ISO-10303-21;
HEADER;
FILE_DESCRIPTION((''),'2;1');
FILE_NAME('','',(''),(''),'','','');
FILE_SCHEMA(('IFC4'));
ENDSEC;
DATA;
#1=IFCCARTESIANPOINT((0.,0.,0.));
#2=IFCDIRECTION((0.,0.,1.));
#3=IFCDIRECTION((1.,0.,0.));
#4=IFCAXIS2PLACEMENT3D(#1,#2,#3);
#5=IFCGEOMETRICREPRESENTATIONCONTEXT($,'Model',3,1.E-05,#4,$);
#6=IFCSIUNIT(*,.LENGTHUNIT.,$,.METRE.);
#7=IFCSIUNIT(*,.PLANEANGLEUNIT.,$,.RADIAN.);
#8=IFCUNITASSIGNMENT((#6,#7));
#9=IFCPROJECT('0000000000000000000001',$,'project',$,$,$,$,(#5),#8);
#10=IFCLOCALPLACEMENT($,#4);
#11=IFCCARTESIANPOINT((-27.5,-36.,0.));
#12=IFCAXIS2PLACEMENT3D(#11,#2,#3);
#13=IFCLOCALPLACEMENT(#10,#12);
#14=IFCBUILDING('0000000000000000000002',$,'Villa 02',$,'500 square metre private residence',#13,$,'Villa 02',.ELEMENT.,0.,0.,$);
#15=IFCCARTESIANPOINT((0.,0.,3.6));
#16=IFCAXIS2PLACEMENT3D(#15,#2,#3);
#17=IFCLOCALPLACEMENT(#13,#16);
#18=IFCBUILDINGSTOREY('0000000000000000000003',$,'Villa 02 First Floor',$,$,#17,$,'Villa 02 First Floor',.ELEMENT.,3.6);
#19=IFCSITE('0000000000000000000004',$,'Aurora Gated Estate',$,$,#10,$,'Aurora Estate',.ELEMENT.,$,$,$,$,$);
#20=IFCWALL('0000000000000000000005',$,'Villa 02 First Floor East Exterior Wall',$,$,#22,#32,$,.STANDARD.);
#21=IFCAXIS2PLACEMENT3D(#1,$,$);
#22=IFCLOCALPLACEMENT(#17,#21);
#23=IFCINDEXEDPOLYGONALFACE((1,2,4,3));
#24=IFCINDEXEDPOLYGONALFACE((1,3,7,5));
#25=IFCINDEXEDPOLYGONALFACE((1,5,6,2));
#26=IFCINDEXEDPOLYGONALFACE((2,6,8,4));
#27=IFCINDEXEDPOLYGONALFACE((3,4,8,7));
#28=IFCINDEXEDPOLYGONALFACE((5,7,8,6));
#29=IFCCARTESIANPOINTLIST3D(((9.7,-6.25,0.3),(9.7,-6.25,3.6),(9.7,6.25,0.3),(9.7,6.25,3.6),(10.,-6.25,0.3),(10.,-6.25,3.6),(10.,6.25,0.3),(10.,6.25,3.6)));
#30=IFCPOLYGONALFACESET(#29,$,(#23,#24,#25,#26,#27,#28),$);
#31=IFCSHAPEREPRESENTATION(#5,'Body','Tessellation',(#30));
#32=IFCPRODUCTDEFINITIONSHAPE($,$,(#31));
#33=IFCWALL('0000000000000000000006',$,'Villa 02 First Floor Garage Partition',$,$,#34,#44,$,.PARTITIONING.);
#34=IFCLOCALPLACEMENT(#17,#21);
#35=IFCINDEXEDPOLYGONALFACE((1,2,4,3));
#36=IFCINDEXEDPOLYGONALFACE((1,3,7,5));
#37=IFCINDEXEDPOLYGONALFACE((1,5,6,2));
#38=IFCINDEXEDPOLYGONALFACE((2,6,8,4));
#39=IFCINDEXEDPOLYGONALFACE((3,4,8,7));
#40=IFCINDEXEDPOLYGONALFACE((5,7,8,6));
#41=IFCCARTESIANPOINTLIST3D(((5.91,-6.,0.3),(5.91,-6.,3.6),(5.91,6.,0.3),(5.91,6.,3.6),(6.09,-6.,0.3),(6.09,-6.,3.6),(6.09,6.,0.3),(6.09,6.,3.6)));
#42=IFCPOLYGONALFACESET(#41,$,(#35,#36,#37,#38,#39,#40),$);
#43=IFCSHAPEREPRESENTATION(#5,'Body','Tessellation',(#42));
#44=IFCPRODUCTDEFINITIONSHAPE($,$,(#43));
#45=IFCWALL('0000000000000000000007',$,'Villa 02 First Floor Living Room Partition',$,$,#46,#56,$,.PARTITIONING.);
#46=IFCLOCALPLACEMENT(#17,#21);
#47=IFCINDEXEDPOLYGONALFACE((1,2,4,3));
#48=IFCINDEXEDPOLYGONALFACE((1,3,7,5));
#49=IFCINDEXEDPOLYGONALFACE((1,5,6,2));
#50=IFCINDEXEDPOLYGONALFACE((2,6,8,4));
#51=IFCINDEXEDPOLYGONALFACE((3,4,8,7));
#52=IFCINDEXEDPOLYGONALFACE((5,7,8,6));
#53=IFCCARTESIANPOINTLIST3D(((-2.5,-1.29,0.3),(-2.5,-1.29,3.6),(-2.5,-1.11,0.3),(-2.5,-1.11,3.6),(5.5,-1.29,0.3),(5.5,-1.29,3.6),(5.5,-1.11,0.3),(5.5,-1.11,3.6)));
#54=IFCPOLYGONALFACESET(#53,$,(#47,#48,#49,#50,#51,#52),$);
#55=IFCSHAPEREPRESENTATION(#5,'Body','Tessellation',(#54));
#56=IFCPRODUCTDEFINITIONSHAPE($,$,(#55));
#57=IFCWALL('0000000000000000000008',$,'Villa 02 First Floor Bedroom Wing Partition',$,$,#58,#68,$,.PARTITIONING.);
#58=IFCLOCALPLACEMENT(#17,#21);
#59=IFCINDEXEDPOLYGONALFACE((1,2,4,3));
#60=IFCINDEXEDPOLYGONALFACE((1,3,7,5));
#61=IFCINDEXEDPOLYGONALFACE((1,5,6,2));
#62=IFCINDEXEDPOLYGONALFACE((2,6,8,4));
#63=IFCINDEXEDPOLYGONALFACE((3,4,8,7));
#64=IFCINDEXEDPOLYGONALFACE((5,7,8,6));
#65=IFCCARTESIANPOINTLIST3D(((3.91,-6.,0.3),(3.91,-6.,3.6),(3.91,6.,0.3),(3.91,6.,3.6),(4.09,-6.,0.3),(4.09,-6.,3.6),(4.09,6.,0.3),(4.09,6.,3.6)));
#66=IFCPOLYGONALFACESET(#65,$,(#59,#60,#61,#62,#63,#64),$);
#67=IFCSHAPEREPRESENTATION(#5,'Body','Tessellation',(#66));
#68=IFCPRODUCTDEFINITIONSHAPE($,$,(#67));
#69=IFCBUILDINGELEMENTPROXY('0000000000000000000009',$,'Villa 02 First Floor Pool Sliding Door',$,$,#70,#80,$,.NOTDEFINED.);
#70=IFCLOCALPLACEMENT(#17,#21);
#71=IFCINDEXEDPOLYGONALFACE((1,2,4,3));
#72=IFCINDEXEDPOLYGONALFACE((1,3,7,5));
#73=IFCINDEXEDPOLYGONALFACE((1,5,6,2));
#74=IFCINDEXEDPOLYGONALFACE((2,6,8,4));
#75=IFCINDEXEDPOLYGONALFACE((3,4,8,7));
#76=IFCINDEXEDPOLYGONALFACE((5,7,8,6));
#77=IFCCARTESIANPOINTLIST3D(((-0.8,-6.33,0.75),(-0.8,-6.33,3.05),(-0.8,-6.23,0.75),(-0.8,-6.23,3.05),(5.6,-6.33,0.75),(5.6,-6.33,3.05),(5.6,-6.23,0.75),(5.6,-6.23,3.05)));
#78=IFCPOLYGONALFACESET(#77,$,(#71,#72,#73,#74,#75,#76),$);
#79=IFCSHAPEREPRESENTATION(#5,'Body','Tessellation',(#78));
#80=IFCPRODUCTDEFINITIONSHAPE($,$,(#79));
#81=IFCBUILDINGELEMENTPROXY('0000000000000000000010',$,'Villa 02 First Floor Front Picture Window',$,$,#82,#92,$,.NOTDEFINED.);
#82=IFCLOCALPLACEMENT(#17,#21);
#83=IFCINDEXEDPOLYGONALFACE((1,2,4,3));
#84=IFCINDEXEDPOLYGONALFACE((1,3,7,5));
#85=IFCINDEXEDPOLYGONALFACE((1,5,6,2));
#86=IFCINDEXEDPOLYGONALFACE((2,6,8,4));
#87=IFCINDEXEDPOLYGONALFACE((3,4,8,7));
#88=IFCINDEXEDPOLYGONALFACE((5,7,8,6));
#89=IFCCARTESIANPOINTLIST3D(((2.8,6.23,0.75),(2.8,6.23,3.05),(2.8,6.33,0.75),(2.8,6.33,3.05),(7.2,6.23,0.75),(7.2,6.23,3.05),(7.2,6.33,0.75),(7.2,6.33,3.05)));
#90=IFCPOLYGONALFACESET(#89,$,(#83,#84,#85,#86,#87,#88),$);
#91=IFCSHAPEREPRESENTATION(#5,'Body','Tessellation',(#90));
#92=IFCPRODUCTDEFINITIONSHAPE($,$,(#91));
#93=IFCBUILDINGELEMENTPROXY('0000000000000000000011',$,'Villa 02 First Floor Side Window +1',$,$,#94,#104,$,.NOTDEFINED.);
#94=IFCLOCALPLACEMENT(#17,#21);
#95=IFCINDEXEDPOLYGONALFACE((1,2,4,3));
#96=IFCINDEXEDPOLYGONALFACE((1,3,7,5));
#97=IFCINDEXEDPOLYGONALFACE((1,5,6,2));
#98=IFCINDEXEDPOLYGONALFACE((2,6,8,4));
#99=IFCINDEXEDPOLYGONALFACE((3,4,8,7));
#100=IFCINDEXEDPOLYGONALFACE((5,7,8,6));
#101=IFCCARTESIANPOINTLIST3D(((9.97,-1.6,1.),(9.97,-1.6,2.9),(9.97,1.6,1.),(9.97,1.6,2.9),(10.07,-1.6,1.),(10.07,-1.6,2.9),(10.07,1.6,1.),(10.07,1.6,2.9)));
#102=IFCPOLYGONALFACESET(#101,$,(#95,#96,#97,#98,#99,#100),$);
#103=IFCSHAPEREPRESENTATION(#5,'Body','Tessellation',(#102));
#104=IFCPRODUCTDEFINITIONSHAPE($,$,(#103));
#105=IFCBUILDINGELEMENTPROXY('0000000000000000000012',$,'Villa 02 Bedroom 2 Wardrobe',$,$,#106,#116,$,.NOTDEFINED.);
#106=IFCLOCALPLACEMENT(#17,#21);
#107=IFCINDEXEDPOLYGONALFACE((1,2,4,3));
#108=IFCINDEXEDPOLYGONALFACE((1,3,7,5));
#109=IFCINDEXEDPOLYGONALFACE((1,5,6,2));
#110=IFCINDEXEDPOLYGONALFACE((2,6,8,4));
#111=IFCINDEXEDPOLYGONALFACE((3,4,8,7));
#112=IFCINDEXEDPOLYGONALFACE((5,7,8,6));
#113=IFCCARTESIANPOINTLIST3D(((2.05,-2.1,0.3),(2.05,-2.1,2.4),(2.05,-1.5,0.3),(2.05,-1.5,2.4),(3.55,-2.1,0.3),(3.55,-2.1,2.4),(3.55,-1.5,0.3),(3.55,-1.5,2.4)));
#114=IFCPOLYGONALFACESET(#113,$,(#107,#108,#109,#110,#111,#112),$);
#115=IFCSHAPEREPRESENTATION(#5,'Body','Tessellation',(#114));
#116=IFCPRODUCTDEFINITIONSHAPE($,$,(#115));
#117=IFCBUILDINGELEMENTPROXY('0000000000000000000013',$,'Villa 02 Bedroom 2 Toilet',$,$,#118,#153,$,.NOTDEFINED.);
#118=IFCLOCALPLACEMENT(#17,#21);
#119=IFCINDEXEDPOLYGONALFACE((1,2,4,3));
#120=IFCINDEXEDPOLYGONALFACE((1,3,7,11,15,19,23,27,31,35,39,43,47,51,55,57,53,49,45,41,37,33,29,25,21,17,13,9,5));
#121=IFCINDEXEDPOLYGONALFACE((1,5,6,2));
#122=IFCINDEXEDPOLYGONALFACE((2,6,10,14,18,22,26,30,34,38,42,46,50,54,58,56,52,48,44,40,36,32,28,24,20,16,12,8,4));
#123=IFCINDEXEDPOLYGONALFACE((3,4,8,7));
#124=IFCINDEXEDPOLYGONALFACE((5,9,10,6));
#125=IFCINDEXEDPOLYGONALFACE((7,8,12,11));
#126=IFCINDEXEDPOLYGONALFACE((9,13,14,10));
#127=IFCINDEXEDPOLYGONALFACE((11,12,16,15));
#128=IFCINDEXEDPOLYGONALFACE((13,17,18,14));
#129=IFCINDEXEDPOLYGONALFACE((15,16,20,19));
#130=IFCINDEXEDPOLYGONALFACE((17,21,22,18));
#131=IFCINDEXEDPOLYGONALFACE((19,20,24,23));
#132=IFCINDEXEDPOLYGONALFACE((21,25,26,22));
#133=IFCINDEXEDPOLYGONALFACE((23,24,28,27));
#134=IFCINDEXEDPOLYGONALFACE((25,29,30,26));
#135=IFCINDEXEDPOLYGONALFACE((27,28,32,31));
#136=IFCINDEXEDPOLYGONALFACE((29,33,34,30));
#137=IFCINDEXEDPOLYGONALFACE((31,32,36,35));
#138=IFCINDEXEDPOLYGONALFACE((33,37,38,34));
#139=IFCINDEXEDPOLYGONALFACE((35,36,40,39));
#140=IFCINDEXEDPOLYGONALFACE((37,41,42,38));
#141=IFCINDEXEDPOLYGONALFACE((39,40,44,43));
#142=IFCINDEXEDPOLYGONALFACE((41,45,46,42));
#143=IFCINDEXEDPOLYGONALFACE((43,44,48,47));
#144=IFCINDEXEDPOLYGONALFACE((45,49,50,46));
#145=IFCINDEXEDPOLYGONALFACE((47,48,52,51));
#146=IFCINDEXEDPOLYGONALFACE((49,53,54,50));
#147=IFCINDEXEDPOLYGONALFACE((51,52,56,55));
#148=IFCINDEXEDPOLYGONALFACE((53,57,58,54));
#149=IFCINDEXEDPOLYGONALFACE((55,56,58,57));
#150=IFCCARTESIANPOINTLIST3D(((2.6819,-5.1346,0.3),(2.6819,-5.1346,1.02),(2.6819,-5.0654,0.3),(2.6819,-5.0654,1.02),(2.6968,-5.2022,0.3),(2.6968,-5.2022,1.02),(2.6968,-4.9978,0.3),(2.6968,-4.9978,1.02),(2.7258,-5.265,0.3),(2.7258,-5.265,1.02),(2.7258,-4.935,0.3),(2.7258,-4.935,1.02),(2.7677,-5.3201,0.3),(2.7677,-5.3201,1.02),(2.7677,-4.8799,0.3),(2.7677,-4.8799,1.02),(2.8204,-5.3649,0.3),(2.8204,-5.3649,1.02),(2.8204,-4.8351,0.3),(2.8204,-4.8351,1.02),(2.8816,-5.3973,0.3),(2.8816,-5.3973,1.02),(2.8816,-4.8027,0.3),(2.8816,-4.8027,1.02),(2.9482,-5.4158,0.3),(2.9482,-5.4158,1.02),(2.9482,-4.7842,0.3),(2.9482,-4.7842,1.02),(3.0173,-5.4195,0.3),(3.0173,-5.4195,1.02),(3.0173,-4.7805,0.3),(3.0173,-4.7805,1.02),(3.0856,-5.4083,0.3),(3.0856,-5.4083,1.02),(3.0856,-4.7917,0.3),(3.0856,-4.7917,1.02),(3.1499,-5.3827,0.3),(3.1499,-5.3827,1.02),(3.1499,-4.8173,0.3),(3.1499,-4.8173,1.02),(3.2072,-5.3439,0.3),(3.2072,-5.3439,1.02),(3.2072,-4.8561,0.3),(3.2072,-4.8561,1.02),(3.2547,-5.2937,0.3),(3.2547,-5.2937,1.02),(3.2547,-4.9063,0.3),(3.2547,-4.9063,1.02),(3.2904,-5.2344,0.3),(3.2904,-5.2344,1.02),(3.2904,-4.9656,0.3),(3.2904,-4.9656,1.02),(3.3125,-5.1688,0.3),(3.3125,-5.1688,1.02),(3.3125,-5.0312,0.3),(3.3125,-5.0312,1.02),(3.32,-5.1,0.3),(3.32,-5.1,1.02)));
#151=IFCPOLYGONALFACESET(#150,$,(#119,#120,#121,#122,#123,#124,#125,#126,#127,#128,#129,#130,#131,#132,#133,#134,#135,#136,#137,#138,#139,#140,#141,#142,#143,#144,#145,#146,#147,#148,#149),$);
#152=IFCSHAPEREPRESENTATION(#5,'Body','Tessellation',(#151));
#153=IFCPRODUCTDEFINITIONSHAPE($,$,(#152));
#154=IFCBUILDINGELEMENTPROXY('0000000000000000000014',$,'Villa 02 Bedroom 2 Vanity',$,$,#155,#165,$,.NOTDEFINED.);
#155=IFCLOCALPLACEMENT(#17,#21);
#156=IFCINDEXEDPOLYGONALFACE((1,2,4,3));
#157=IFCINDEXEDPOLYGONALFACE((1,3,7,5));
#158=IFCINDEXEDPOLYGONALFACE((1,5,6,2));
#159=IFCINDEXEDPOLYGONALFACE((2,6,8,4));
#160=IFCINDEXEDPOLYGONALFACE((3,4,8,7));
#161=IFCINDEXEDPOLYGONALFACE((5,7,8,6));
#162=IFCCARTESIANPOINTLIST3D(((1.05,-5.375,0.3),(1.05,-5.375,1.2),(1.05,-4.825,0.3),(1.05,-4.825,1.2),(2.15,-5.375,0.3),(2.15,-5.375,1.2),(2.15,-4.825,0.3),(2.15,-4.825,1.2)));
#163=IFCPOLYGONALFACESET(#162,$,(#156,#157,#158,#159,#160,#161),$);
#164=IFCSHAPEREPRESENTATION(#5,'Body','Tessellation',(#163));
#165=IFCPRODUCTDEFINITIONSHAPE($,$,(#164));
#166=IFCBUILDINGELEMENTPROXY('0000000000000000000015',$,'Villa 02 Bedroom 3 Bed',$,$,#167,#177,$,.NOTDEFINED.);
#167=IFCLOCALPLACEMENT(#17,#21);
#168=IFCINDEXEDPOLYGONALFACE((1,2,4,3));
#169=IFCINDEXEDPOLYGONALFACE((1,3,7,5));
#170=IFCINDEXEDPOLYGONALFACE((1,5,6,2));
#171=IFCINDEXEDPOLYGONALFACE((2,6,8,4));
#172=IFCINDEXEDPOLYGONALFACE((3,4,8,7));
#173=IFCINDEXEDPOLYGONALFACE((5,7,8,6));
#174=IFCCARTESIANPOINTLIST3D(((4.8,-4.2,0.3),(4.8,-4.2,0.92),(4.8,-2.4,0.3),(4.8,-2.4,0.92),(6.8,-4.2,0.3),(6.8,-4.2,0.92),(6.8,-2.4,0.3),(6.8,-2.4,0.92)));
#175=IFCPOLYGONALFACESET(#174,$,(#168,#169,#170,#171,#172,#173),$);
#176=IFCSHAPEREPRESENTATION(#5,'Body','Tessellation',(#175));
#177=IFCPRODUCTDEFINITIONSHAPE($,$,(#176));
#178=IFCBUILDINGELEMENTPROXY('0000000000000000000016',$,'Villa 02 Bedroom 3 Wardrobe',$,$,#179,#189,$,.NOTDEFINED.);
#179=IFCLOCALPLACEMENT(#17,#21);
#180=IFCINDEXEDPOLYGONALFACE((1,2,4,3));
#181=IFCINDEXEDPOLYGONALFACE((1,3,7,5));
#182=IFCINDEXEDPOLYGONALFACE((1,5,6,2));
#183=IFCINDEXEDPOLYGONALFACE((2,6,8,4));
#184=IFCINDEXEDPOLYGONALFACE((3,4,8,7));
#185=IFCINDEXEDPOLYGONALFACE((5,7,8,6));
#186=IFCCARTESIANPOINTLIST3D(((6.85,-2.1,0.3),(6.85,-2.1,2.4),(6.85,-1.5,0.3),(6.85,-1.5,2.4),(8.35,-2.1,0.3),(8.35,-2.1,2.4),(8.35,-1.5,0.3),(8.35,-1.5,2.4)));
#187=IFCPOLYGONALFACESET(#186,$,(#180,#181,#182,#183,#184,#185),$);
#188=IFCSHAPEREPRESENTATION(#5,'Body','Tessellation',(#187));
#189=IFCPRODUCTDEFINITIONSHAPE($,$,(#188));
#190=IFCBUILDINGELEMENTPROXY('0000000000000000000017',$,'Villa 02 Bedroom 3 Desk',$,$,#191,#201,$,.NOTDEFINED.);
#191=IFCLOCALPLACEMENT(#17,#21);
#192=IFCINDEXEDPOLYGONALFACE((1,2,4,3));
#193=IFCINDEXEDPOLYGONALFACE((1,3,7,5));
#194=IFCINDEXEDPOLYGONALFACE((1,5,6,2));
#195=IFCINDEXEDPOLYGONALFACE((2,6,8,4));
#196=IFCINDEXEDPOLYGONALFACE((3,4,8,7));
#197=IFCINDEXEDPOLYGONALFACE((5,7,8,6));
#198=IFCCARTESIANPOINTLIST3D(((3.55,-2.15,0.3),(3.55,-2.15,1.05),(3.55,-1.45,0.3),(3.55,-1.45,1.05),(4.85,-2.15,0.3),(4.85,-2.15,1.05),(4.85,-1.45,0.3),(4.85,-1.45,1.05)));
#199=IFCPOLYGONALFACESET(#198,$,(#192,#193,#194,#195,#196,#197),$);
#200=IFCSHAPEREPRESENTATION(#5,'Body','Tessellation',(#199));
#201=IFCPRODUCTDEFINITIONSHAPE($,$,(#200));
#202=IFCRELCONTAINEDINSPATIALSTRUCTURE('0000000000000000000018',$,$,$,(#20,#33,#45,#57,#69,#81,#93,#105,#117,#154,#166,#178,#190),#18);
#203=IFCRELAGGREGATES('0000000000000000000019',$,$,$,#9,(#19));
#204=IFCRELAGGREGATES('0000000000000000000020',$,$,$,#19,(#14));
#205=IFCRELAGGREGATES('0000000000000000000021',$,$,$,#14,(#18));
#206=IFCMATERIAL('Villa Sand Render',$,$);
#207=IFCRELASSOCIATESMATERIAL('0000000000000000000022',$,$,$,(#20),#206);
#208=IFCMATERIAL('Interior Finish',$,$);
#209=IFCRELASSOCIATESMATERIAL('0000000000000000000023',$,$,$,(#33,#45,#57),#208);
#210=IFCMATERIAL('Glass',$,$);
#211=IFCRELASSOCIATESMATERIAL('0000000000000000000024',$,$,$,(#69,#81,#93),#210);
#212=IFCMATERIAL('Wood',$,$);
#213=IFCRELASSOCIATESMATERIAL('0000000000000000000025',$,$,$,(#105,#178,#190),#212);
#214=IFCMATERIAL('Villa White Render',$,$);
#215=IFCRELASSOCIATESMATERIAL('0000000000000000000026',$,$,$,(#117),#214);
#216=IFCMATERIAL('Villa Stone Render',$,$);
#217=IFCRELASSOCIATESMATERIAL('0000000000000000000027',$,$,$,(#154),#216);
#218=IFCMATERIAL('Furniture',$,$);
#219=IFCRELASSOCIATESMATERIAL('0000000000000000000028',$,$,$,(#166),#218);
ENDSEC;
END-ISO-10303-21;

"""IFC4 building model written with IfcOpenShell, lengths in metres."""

from ifc_helpers import new_model, si_unit, frame, origin_with_axes, origin_2d_with_axis, place, context, project, spatial, rectangle, circle, extrude, material, element, save


model = new_model("IFC4")

# Units and contexts
model_context = context("Model", 3, precision=1e-05, world=origin_with_axes())
ifc_project = project(units=[si_unit("LENGTHUNIT", "METRE"), si_unit("PLANEANGLEUNIT", "RADIAN")], contexts=[model_context])

# Site, building, storey
site_placement = place(None, origin_with_axes())
site = spatial("IfcSite", under=ifc_project, at=site_placement, Name="Aurora Gated Estate", LongName="Aurora Estate", CompositionType="ELEMENT")
building_placement = place(site_placement, frame((-27.5, -36.0, 0.0), z_axis=(0.0, 0.0, 1.0), x_axis=(1.0, 0.0, 0.0)))
building = spatial("IfcBuilding", under=site, at=building_placement, Name="Villa 02", ObjectType="500 square metre private residence", LongName="Villa 02", CompositionType="ELEMENT", ElevationOfRefHeight=0.0, ElevationOfTerrain=0.0)
storey_placement = place(building_placement, frame((0.0, 0.0, 3.6), z_axis=(0.0, 0.0, 1.0), x_axis=(1.0, 0.0, 0.0)))
storey = spatial("IfcBuildingStorey", under=building, at=storey_placement, Name="Villa 02 First Floor", LongName="Villa 02 First Floor", CompositionType="ELEMENT", Elevation=3.6)

# Walls
ifc_material_1 = material(Name="Villa Sand Render")
wall_1_placement = place(storey_placement, frame((9.85, 0.0, 0.3), z_axis=(0.0, 0.0, 1.0), x_axis=(1.0, 0.0, 0.0)))
element("IfcWall", 1, at=wall_1_placement, inside=storey, material=ifc_material_1, Name="Villa 02 First Floor East Exterior Wall", PredefinedType="STANDARD", context=model_context, shape_type="SweptSolid", body=[
    extrude(rectangle(XDim=0.3, YDim=12.5, at=origin_2d_with_axis()), origin_with_axes(), (0.0, 0.0, 1.0), 3.3),
])
ifc_material_2 = material(Name="Interior Finish")
wall_2_placement = place(storey_placement, frame((6.0, 0.0, 0.3), z_axis=(0.0, 0.0, 1.0), x_axis=(1.0, 0.0, 0.0)))
element("IfcWall", 2, at=wall_2_placement, inside=storey, material=ifc_material_2, Name="Villa 02 First Floor Garage Partition", PredefinedType="PARTITIONING", context=model_context, shape_type="SweptSolid", body=[
    extrude(rectangle(XDim=0.18, YDim=12.0, at=origin_2d_with_axis()), origin_with_axes(), (0.0, 0.0, 1.0), 3.3),
])
wall_3_placement = place(storey_placement, frame((1.5, -1.2, 0.3), z_axis=(0.0, 0.0, 1.0), x_axis=(1.0, 0.0, 0.0)))
element("IfcWall", 3, at=wall_3_placement, inside=storey, material=ifc_material_2, Name="Villa 02 First Floor Living Room Partition", PredefinedType="PARTITIONING", context=model_context, shape_type="SweptSolid", body=[
    extrude(rectangle(XDim=8.0, YDim=0.18, at=origin_2d_with_axis()), origin_with_axes(), (0.0, 0.0, 1.0), 3.3),
])
wall_4_placement = place(storey_placement, frame((4.0, 0.0, 0.3), z_axis=(0.0, 0.0, 1.0), x_axis=(1.0, 0.0, 0.0)))
element("IfcWall", 4, at=wall_4_placement, inside=storey, material=ifc_material_2, Name="Villa 02 First Floor Bedroom Wing Partition", PredefinedType="PARTITIONING", context=model_context, shape_type="SweptSolid", body=[
    extrude(rectangle(XDim=0.18, YDim=12.0, at=origin_2d_with_axis()), origin_with_axes(), (0.0, 0.0, 1.0), 3.3),
])

# Building element proxies
ifc_material_3 = material(Name="Glass")
proxy_1_placement = place(storey_placement, frame((2.4, -6.28, 0.75), z_axis=(0.0, 0.0, 1.0), x_axis=(1.0, 0.0, 0.0)))
element("IfcBuildingElementProxy", 5, at=proxy_1_placement, inside=storey, material=ifc_material_3, Name="Villa 02 First Floor Pool Sliding Door", PredefinedType="NOTDEFINED", context=model_context, shape_type="SweptSolid", body=[
    extrude(rectangle(XDim=6.4, YDim=0.1, at=origin_2d_with_axis()), origin_with_axes(), (0.0, 0.0, 1.0), 2.3),
])
proxy_2_placement = place(storey_placement, frame((5.0, 6.28, 0.75), z_axis=(0.0, 0.0, 1.0), x_axis=(1.0, 0.0, 0.0)))
element("IfcBuildingElementProxy", 6, at=proxy_2_placement, inside=storey, material=ifc_material_3, Name="Villa 02 First Floor Front Picture Window", PredefinedType="NOTDEFINED", context=model_context, shape_type="SweptSolid", body=[
    extrude(rectangle(XDim=4.4, YDim=0.1, at=origin_2d_with_axis()), origin_with_axes(), (0.0, 0.0, 1.0), 2.3),
])
proxy_3_placement = place(storey_placement, frame((10.02, 0.0, 1.0), z_axis=(0.0, 0.0, 1.0), x_axis=(0.0, 1.0, 0.0)))
element("IfcBuildingElementProxy", 7, at=proxy_3_placement, inside=storey, material=ifc_material_3, Name="Villa 02 First Floor Side Window +1", PredefinedType="NOTDEFINED", context=model_context, shape_type="SweptSolid", body=[
    extrude(rectangle(XDim=3.2, YDim=0.1, at=origin_2d_with_axis()), origin_with_axes(), (0.0, 0.0, 1.0), 1.9),
])
ifc_material_4 = material(Name="Wood")
proxy_4_placement = place(storey_placement, frame((2.8, -1.8, 0.3), z_axis=(0.0, 0.0, 1.0), x_axis=(1.0, 0.0, 0.0)))
element("IfcBuildingElementProxy", 8, at=proxy_4_placement, inside=storey, material=ifc_material_4, Name="Villa 02 Bedroom 2 Wardrobe", PredefinedType="NOTDEFINED", context=model_context, shape_type="SweptSolid", body=[
    extrude(rectangle(XDim=1.5, YDim=0.6, at=origin_2d_with_axis()), origin_with_axes(), (0.0, 0.0, 1.0), 2.1),
])
ifc_material_5 = material(Name="Villa White Render")
proxy_5_placement = place(storey_placement, frame((3.0, -5.1, 0.3), z_axis=(0.0, 0.0, 1.0), x_axis=(1.0, 0.0, 0.0)))
element("IfcBuildingElementProxy", 9, at=proxy_5_placement, inside=storey, material=ifc_material_5, Name="Villa 02 Bedroom 2 Toilet", PredefinedType="NOTDEFINED", context=model_context, shape_type="SweptSolid", body=[
    extrude(circle(Radius=0.32, at=origin_2d_with_axis()), origin_with_axes(), (0.0, 0.0, 1.0), 0.72),
])
ifc_material_6 = material(Name="Villa Stone Render")
proxy_6_placement = place(storey_placement, frame((1.6, -5.1, 0.3), z_axis=(0.0, 0.0, 1.0), x_axis=(1.0, 0.0, 0.0)))
element("IfcBuildingElementProxy", 10, at=proxy_6_placement, inside=storey, material=ifc_material_6, Name="Villa 02 Bedroom 2 Vanity", PredefinedType="NOTDEFINED", context=model_context, shape_type="SweptSolid", body=[
    extrude(rectangle(XDim=1.1, YDim=0.55, at=origin_2d_with_axis()), origin_with_axes(), (0.0, 0.0, 1.0), 0.9),
])
ifc_material_7 = material(Name="Furniture")
proxy_7_placement = place(storey_placement, frame((5.8, -3.3, 0.3), z_axis=(0.0, 0.0, 1.0), x_axis=(1.0, 0.0, 0.0)))
element("IfcBuildingElementProxy", 11, at=proxy_7_placement, inside=storey, material=ifc_material_7, Name="Villa 02 Bedroom 3 Bed", PredefinedType="NOTDEFINED", context=model_context, shape_type="SweptSolid", body=[
    extrude(rectangle(XDim=2.0, YDim=1.8, at=origin_2d_with_axis()), origin_with_axes(), (0.0, 0.0, 1.0), 0.62),
])
proxy_8_placement = place(storey_placement, frame((7.6, -1.8, 0.3), z_axis=(0.0, 0.0, 1.0), x_axis=(1.0, 0.0, 0.0)))
element("IfcBuildingElementProxy", 12, at=proxy_8_placement, inside=storey, material=ifc_material_4, Name="Villa 02 Bedroom 3 Wardrobe", PredefinedType="NOTDEFINED", context=model_context, shape_type="SweptSolid", body=[
    extrude(rectangle(XDim=1.5, YDim=0.6, at=origin_2d_with_axis()), origin_with_axes(), (0.0, 0.0, 1.0), 2.1),
])
proxy_9_placement = place(storey_placement, frame((4.2, -1.8, 0.3), z_axis=(0.0, 0.0, 1.0), x_axis=(1.0, 0.0, 0.0)))
element("IfcBuildingElementProxy", 13, at=proxy_9_placement, inside=storey, material=ifc_material_4, Name="Villa 02 Bedroom 3 Desk", PredefinedType="NOTDEFINED", context=model_context, shape_type="SweptSolid", body=[
    extrude(rectangle(XDim=1.3, YDim=0.7, at=origin_2d_with_axis()), origin_with_axes(), (0.0, 0.0, 1.0), 0.75),
])

save(model, "model.ifc")
